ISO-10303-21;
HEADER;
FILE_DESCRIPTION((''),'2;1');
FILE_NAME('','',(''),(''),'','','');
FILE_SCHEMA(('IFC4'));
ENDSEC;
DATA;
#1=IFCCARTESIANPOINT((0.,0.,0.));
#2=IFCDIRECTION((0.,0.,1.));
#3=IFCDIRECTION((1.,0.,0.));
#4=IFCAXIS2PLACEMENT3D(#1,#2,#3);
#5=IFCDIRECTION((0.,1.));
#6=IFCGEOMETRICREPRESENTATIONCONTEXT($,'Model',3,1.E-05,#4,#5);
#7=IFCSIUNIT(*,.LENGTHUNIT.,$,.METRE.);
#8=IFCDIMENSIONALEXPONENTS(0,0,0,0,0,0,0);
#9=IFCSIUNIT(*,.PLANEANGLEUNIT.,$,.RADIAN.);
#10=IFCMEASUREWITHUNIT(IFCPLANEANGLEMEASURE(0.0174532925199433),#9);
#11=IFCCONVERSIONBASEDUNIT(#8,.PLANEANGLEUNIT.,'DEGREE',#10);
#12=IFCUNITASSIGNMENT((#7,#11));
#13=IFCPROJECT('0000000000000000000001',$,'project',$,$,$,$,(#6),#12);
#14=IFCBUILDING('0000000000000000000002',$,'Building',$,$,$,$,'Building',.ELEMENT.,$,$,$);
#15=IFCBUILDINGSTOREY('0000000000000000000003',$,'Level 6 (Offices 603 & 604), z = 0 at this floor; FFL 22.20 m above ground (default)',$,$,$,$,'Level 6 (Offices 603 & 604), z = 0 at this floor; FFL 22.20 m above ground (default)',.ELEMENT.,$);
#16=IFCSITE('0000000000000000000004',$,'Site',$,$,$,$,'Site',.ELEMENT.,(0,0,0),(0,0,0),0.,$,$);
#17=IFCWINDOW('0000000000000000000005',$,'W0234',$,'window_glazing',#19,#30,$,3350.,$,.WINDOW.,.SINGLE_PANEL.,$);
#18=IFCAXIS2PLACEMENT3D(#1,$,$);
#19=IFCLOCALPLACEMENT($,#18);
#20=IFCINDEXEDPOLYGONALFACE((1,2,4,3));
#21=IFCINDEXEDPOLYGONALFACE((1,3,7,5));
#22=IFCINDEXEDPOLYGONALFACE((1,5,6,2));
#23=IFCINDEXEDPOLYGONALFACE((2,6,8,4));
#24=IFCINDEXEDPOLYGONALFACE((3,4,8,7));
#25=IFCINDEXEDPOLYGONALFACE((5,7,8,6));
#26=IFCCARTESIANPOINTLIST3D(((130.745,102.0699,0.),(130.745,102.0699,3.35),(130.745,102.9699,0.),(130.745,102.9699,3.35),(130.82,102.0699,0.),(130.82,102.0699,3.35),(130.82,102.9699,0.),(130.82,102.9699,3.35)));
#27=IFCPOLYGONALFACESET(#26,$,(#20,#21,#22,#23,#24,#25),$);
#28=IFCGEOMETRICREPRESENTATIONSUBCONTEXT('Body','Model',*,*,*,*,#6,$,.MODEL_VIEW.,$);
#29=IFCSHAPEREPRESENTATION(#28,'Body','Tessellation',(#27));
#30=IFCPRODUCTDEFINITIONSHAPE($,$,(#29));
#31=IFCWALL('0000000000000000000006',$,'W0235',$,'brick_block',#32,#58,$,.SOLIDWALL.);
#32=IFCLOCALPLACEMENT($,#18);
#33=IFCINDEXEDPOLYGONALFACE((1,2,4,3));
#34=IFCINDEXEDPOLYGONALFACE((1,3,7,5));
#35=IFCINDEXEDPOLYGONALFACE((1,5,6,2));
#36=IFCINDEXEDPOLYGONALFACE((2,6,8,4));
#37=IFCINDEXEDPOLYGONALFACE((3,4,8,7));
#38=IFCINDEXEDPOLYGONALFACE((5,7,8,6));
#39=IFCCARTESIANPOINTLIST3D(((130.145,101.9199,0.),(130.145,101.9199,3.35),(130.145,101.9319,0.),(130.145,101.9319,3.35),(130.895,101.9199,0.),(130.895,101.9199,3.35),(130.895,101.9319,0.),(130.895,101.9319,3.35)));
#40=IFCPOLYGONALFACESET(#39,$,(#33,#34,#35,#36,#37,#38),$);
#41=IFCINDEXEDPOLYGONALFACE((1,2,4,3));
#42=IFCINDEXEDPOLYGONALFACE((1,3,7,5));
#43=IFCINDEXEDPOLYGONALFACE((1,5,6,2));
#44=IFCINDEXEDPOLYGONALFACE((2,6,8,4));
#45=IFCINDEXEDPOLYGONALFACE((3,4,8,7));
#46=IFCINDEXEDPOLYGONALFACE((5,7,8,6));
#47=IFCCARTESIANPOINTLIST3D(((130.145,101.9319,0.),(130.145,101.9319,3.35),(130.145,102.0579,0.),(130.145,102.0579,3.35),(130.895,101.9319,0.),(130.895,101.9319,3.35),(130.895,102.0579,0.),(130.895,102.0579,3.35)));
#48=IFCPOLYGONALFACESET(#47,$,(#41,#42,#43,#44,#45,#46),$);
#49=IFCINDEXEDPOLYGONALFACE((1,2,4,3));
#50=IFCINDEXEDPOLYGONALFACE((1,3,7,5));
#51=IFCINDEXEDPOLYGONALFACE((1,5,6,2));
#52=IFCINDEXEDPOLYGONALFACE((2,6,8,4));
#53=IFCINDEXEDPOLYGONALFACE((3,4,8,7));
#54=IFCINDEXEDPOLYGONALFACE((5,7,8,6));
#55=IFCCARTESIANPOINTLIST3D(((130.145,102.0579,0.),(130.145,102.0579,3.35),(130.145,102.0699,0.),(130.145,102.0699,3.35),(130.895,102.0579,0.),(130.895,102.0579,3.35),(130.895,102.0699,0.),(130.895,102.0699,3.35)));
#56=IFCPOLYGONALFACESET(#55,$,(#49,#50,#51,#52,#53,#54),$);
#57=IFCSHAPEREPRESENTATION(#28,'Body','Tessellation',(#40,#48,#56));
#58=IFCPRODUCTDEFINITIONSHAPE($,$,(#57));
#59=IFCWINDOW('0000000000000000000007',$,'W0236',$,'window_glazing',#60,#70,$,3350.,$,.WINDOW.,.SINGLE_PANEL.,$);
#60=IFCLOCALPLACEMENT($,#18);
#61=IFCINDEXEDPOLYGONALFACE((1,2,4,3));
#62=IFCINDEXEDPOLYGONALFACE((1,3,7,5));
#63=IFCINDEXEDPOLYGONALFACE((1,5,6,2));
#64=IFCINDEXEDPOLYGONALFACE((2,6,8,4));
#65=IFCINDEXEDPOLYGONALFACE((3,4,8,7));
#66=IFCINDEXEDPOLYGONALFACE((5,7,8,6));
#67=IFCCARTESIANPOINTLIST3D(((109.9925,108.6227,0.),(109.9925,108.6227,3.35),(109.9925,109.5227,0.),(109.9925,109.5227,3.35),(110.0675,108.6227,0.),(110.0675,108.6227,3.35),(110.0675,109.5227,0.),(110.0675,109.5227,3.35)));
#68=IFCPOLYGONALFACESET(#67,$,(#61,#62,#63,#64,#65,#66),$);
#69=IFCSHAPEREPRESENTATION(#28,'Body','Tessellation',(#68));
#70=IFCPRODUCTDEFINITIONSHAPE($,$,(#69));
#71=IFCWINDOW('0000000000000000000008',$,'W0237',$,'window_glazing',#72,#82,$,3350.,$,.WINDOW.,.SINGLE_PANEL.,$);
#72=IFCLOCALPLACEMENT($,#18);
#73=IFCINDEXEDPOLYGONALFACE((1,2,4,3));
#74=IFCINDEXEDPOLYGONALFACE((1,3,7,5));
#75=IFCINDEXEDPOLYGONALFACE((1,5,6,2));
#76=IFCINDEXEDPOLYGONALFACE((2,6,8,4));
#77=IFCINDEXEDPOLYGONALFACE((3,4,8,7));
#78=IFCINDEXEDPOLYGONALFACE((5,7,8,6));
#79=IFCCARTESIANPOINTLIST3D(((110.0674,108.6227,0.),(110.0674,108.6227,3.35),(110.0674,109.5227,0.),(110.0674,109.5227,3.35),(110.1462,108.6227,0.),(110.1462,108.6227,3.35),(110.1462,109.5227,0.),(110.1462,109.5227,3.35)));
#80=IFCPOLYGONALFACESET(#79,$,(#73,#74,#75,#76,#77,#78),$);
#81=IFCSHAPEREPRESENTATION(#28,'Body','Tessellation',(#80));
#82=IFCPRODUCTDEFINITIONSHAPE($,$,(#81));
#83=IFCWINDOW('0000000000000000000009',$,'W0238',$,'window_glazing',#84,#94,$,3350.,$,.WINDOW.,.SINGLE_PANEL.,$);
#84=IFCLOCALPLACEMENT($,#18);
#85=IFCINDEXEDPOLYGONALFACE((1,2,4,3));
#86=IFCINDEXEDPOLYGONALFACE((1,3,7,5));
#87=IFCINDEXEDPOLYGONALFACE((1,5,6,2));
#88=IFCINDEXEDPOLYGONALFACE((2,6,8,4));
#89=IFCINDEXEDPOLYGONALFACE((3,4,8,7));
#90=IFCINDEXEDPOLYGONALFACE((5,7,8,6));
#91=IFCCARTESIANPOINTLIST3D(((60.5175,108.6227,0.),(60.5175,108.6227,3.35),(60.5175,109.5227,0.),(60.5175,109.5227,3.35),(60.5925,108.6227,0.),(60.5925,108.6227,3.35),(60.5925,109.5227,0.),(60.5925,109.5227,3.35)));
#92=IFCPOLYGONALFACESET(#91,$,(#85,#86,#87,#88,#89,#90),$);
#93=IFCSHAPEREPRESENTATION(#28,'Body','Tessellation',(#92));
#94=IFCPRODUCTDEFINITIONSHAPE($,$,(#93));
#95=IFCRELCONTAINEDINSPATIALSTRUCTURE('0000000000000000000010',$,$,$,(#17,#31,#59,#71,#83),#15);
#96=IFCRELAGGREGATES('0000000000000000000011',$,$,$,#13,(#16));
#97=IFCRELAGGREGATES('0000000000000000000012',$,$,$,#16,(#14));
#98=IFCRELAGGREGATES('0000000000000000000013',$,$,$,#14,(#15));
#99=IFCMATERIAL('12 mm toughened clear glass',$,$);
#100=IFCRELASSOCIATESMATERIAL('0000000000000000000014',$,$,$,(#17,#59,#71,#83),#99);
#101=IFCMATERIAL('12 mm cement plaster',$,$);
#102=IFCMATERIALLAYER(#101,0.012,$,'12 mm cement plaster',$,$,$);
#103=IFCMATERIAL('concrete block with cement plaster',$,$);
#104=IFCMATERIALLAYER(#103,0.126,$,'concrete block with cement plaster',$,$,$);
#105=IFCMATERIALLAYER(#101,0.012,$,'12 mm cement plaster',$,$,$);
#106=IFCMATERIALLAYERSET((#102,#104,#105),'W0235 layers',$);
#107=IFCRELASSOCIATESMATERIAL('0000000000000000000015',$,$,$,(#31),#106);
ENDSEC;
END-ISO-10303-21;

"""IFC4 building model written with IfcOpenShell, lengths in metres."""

from ifc_helpers import new_model, entity, si_unit, converted_unit, direction, frame, frame_2d, origin_with_axes, place, context, subcontext, project, spatial, rectangle, extrude, material, layer, layer_set, layer_usage, element, save


model = new_model("IFC4")

# Units and contexts
model_context = context("Model", 3, precision=1e-05, world=origin_with_axes(), true_north=direction((0.0, 1.0)))
body_context = subcontext(model_context, "Body", "Model", "MODEL_VIEW")
ifc_project = project(units=[si_unit("LENGTHUNIT", "METRE"), converted_unit("PLANEANGLEUNIT", "DEGREE", entity("IfcPlaneAngleMeasure", 0.0174532925199433), si_unit("PLANEANGLEUNIT", "RADIAN"), dimensions=[0, 0, 0, 0, 0, 0, 0])], contexts=[model_context])

# Site, building, storey
site = spatial("IfcSite", under=ifc_project, Name="Site", LongName="Site", CompositionType="ELEMENT", RefLatitude=(0, 0, 0), RefLongitude=(0, 0, 0), RefElevation=0.0)
building = spatial("IfcBuilding", under=site, Name="Building", LongName="Building", CompositionType="ELEMENT")
storey = spatial("IfcBuildingStorey", under=building, Name="Level 6 (Offices 603 & 604), z = 0 at this floor; FFL 22.20 m above ground (default)", LongName="Level 6 (Offices 603 & 604), z = 0 at this floor; FFL 22.20 m above ground (default)", CompositionType="ELEMENT")

# Shared definitions
ifc_material_1 = material(Name="12 mm cement plaster")
ifc_material_2 = material(Name="concrete block with cement plaster")
placement = place(None, origin_with_axes())

# Shared definitions
ifc_material_3 = material(Name="12 mm toughened clear glass")

# Window
element("IfcWindow", 1, at=placement, inside=storey, material=ifc_material_3, Name="W0234", ObjectType="window_glazing", OverallHeight=3350.0, PartitioningType="SINGLE_PANEL", PredefinedType="WINDOW", context=body_context, shape_type="SweptSolid", body=[
    extrude(rectangle(XDim=0.9, YDim=0.075, at=frame_2d((0.0, 0.0), x_axis=(0.0, 1.0))), frame((130.7825, 102.5199, 0.0), z_axis=(0.0, 0.0, 1.0), x_axis=(1.0, 0.0, 0.0)), (0.0, 0.0, 1.0), 3.35),
])

# Wall
ifc_layer_1 = layer(ifc_material_1, 0.012, Name="12 mm cement plaster")
ifc_layer_2 = layer(ifc_material_2, 0.126, Name="concrete block with cement plaster")
ifc_layer_3 = layer(ifc_material_1, 0.012, Name="12 mm cement plaster")
ifc_layer_set_1 = layer_set([ifc_layer_1, ifc_layer_2, ifc_layer_3], Name="W0235 layers")
ifc_layer_usage_1 = layer_usage(ifc_layer_set_1, "AXIS2", "POSITIVE", -0.075)
element("IfcWall", 2, at=placement, inside=storey, material=ifc_layer_usage_1, Name="W0235", ObjectType="brick_block", PredefinedType="SOLIDWALL", context=body_context, shape_type="SweptSolid", body=[
    extrude(rectangle(XDim=0.75, YDim=0.012, at=frame_2d((0.0, 0.0), x_axis=(1.0, 0.0))), frame((130.52, 101.9259, 0.0), z_axis=(0.0, 0.0, 1.0), x_axis=(1.0, 0.0, 0.0)), (0.0, 0.0, 1.0), 3.35),
    extrude(rectangle(XDim=0.75, YDim=0.126, at=frame_2d((0.0, 0.069), x_axis=(1.0, 0.0))), frame((130.52, 101.9259, 0.0), z_axis=(0.0, 0.0, 1.0), x_axis=(1.0, 0.0, 0.0)), (0.0, 0.0, 1.0), 3.35),
    extrude(rectangle(XDim=0.75, YDim=0.012, at=frame_2d((0.0, 0.138), x_axis=(1.0, 0.0))), frame((130.52, 101.9259, 0.0), z_axis=(0.0, 0.0, 1.0), x_axis=(1.0, 0.0, 0.0)), (0.0, 0.0, 1.0), 3.35),
])

# Windows
element("IfcWindow", 3, at=placement, inside=storey, material=ifc_material_3, Name="W0236", ObjectType="window_glazing", OverallHeight=3350.0, PartitioningType="SINGLE_PANEL", PredefinedType="WINDOW", context=body_context, shape_type="SweptSolid", body=[
    extrude(rectangle(XDim=0.9, YDim=0.075, at=frame_2d((0.0, 0.0), x_axis=(0.0, 1.0))), frame((110.03, 109.0727, 0.0), z_axis=(0.0, 0.0, 1.0), x_axis=(1.0, 0.0, 0.0)), (0.0, 0.0, 1.0), 3.35),
])
element("IfcWindow", 4, at=placement, inside=storey, material=ifc_material_3, Name="W0237", ObjectType="window_glazing", OverallHeight=3350.0, PartitioningType="SINGLE_PANEL", PredefinedType="WINDOW", context=body_context, shape_type="SweptSolid", body=[
    extrude(rectangle(XDim=0.9, YDim=0.0787, at=frame_2d((0.0, 0.0), x_axis=(0.0, 1.0))), frame((110.1068, 109.0727, 0.0), z_axis=(0.0, 0.0, 1.0), x_axis=(1.0, 0.0, 0.0)), (0.0, 0.0, 1.0), 3.35),
])
element("IfcWindow", 5, at=placement, inside=storey, material=ifc_material_3, Name="W0238", ObjectType="window_glazing", OverallHeight=3350.0, PartitioningType="SINGLE_PANEL", PredefinedType="WINDOW", context=body_context, shape_type="SweptSolid", body=[
    extrude(rectangle(XDim=0.9, YDim=0.075, at=frame_2d((0.0, 0.0), x_axis=(0.0, 1.0))), frame((60.555, 109.0727, 0.0), z_axis=(0.0, 0.0, 1.0), x_axis=(1.0, 0.0, 0.0)), (0.0, 0.0, 1.0), 3.35),
])

save(model, "model.ifc")
